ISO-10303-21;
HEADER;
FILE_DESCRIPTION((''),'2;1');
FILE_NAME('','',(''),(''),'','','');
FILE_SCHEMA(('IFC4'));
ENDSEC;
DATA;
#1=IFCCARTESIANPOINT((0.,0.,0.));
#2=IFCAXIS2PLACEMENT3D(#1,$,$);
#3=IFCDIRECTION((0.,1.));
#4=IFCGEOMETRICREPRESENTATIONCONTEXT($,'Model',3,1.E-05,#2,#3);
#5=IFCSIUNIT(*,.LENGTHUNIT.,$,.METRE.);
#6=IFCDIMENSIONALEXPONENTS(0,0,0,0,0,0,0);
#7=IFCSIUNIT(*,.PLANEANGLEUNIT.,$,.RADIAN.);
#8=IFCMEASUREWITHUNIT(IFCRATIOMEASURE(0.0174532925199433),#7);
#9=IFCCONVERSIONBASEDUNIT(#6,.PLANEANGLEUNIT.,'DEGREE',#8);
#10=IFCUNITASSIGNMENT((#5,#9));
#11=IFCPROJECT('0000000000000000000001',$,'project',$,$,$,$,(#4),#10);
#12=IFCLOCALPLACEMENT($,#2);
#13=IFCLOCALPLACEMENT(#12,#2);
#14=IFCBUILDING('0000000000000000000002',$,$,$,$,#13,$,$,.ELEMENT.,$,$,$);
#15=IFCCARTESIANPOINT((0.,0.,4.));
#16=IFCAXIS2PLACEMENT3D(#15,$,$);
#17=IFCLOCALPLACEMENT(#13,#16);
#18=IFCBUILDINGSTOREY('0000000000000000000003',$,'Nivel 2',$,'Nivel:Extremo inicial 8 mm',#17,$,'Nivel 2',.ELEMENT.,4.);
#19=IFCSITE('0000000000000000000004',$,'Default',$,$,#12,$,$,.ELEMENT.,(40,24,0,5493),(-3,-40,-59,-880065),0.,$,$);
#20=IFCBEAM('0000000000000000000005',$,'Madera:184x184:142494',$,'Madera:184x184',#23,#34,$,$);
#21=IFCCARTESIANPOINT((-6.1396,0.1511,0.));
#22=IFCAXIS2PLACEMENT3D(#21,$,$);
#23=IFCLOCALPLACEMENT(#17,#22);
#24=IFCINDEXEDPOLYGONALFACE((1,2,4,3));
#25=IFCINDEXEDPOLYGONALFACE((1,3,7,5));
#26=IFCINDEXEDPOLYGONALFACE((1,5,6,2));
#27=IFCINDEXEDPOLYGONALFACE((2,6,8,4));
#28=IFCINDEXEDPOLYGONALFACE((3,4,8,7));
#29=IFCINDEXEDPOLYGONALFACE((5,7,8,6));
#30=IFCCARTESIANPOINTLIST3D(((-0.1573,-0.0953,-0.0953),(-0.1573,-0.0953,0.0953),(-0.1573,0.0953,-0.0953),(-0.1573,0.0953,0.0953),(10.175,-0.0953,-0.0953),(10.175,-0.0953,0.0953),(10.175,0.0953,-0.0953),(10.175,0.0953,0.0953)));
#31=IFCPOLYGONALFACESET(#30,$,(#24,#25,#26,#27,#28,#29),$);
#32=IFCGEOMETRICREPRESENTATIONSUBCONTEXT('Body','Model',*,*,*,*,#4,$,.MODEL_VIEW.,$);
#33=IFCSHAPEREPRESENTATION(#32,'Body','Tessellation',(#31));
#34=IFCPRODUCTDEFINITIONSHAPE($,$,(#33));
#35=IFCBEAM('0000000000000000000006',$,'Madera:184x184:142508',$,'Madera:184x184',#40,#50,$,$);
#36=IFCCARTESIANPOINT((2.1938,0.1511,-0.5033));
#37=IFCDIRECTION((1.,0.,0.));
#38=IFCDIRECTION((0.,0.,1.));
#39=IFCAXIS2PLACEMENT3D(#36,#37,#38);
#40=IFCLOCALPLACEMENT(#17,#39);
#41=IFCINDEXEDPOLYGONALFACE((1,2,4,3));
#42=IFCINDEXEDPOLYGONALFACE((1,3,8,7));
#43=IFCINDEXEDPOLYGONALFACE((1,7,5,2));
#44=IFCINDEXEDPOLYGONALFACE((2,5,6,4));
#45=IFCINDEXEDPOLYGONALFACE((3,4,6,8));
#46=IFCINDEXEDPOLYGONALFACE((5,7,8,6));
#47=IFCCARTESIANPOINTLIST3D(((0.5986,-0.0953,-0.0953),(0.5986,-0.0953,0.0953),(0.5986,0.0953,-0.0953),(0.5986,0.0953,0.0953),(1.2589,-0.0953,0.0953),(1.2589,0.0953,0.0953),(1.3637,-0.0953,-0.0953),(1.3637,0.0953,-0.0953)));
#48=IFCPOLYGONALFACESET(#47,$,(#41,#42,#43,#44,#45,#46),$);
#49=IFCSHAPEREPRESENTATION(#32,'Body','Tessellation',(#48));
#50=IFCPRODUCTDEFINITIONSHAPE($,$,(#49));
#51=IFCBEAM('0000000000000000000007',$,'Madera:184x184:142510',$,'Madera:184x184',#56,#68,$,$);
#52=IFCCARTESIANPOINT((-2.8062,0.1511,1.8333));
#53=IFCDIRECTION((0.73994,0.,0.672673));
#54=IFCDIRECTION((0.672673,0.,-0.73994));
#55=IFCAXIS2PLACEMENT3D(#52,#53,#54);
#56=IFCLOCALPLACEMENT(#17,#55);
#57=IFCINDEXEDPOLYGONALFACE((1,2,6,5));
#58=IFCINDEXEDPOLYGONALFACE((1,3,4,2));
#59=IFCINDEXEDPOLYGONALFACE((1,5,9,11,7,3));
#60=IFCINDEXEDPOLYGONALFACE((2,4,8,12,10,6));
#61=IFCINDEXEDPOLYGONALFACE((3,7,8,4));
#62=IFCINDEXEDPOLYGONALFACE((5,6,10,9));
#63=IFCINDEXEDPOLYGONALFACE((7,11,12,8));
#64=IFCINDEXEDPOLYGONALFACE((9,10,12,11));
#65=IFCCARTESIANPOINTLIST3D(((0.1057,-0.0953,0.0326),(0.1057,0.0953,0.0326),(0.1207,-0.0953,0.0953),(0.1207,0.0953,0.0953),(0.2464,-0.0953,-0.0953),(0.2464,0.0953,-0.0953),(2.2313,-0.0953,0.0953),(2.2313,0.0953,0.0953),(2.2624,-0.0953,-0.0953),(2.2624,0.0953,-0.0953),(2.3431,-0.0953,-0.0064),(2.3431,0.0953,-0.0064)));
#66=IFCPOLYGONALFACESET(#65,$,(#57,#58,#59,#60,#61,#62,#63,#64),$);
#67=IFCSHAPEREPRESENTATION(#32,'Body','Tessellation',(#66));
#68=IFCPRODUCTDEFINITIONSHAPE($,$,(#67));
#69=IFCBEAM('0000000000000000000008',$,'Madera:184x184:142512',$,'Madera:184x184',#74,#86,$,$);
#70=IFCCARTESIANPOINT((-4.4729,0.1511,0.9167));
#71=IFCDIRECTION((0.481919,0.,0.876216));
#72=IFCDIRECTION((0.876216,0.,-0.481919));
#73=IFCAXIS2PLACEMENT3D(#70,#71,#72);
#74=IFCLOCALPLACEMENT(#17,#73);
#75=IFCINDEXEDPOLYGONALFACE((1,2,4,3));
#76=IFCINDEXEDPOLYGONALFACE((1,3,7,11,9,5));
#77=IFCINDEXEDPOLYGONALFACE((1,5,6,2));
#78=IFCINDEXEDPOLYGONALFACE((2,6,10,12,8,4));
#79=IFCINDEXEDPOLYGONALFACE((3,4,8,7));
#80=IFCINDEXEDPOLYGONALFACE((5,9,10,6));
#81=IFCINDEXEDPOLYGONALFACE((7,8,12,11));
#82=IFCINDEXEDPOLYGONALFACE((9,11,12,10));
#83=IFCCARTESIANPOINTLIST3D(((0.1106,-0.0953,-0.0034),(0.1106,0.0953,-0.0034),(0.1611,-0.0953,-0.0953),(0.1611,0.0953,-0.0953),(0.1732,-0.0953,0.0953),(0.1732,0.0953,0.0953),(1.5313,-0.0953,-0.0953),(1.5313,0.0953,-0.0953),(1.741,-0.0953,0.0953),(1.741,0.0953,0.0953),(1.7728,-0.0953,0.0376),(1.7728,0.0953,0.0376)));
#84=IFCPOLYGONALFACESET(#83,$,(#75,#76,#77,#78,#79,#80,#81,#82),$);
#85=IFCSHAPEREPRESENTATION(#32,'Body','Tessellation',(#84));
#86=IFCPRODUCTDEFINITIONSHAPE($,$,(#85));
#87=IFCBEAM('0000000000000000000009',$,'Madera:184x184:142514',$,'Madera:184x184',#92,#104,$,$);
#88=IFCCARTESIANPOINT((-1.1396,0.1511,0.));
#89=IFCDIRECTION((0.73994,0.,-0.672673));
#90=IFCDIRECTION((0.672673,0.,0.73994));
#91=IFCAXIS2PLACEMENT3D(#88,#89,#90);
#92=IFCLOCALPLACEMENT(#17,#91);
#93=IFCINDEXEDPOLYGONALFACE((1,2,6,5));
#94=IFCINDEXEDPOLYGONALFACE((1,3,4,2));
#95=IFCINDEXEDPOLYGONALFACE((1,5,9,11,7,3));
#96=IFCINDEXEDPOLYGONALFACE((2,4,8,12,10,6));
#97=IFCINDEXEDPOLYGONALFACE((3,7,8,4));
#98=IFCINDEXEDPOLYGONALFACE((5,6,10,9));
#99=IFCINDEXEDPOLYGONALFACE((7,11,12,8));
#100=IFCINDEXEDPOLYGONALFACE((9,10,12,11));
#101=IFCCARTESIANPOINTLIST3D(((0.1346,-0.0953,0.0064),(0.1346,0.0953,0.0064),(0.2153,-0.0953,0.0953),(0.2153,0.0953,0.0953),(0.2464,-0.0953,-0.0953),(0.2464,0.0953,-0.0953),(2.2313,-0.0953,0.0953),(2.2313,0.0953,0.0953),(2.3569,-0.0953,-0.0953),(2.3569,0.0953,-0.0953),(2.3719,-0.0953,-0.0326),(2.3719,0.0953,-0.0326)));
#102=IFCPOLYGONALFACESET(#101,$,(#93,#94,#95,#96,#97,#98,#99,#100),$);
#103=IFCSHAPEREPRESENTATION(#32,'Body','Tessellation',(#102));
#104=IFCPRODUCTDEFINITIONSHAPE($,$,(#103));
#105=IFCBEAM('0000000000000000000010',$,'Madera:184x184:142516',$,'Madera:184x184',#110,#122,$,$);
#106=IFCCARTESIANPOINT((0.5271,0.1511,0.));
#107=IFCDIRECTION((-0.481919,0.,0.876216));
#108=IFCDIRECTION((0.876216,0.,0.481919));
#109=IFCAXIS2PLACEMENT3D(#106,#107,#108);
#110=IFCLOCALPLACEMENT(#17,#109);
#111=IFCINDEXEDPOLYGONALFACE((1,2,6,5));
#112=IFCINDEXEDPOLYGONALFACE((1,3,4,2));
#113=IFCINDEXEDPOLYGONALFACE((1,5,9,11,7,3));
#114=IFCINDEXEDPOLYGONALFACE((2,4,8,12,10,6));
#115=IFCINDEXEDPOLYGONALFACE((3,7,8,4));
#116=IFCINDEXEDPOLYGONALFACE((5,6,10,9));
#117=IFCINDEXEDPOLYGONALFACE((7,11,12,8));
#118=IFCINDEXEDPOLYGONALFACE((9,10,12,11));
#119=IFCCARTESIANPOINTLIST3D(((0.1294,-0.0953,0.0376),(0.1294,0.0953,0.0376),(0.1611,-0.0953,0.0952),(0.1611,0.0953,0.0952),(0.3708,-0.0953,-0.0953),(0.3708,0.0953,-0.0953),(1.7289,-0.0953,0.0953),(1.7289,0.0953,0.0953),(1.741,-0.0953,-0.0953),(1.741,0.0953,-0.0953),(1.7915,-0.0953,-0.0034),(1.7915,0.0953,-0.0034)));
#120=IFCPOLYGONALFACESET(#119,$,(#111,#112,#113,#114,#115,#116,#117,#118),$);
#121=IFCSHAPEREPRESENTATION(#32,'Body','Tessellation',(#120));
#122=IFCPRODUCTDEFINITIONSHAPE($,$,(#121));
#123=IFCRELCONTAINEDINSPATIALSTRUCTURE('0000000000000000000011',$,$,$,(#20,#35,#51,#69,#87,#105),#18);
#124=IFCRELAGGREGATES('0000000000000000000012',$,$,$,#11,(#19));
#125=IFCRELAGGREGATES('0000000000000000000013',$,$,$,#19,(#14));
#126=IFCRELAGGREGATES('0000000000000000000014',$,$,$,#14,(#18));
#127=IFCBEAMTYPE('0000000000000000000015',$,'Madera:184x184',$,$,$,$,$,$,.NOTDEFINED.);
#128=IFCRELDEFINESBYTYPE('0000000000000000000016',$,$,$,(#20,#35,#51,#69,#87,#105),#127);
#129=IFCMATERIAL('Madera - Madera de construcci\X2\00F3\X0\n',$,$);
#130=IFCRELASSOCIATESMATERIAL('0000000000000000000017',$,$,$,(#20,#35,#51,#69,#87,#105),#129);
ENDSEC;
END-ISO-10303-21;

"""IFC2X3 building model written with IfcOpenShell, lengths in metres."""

from ifc_helpers import new_model, entity, si_unit, converted_unit, direction, frame, frame_2d, origin, origin_2d_with_axis, place, context, subcontext, project, spatial, rectangle, extrude, clip, halfspace, material, type_object, element, save


model = new_model("IFC2X3")

# Units and contexts
model_context = context("Model", 3, precision=1e-05, world=origin(), true_north=direction((0.0, 1.0)))
body_context = subcontext(model_context, "Body", "Model", "MODEL_VIEW")
ifc_project = project(units=[si_unit("LENGTHUNIT", "METRE"), converted_unit("PLANEANGLEUNIT", "DEGREE", entity("IfcRatioMeasure", 0.0174532925199433), si_unit("PLANEANGLEUNIT", "RADIAN"), dimensions=[0, 0, 0, 0, 0, 0, 0])], contexts=[model_context])

# Site, building, storey
site_placement = place(None, origin())
site = spatial("IfcSite", under=ifc_project, at=site_placement, Name="Default", CompositionType="ELEMENT", RefLatitude=(40, 24, 0, 5493), RefLongitude=(-3, -40, -59, -880065), RefElevation=0.0)
building_placement = place(site_placement, origin())
building = spatial("IfcBuilding", under=site, at=building_placement, CompositionType="ELEMENT")
storey_placement = place(building_placement, frame((0.0, 0.0, 4.0)))
storey = spatial("IfcBuildingStorey", under=building, at=storey_placement, Name="Nivel 2", ObjectType="Nivel:Extremo inicial 8 mm", LongName="Nivel 2", CompositionType="ELEMENT", Elevation=4.0)

# Beams
ifc_material = material(Name="Madera - Madera de construcción")
beam_type = type_object("IfcBeamType", Name="Madera:184x184", PredefinedType="NOTDEFINED")
beam_1_placement = place(storey_placement, frame((-6.1396, 0.1511, 0.0)))
element("IfcBeam", 1, at=beam_1_placement, inside=storey, type_object=beam_type, material=ifc_material, Name="Madera:184x184:142494", ObjectType="Madera:184x184", context=body_context, shape_type="SweptSolid", body=[
    extrude(rectangle(XDim=0.1905, YDim=0.1905, at=frame_2d((0.0, 0.0), x_axis=(1.0, 0.0))), frame((-0.1573, 0.0, 0.0), z_axis=(1.0, 0.0, 0.0), x_axis=(0.0, 0.0, -1.0)), (0.0, 0.0, 1.0), 10.3323),
])
beam_2_placement = place(storey_placement, frame((2.1938, 0.1511, -0.5033), z_axis=(1.0, 0.0, 0.0), x_axis=(0.0, 0.0, 1.0)))
element("IfcBeam", 2, at=beam_2_placement, inside=storey, type_object=beam_type, material=ifc_material, Name="Madera:184x184:142508", ObjectType="Madera:184x184", context=body_context, shape_type="Clipping", body=[
    clip(extrude(rectangle(XDim=0.1905, YDim=0.1905, at=origin_2d_with_axis()), frame((0.5986, 0.0, 0.0), z_axis=(1.0, 0.0, 0.0), x_axis=(0.0, 0.0, -1.0)), (0.0, 0.0, 1.0), 0.7651), halfspace(frame((3.1698, -0.0953, -3.3791), z_axis=(0.876216, 0.0, 0.481919), x_axis=(-0.481919, 0.0, 0.876216)), False)),
])
beam_3_placement = place(storey_placement, frame((-2.8062, 0.1511, 1.8333), z_axis=(0.73994, 0.0, 0.672673), x_axis=(0.672673, 0.0, -0.73994)))
element("IfcBeam", 3, at=beam_3_placement, inside=storey, type_object=beam_type, material=ifc_material, Name="Madera:184x184:142510", ObjectType="Madera:184x184", context=body_context, shape_type="Clipping", body=[
    clip(clip(clip(clip(extrude(rectangle(XDim=0.1905, YDim=0.1905, at=frame_2d((0.0, 0.0), x_axis=(0.0, 1.0))), frame((0.1057, 0.0, 0.0), z_axis=(1.0, 0.0, 0.0), x_axis=(0.0, 1.0, 0.0)), (0.0, 0.0, 1.0), 2.2374), halfspace(frame((-1.062, -0.0952, -3.752), z_axis=(0.73994, 0.0, -0.672673), x_axis=(0.672673, 0.0, 0.73994)), False)), halfspace(frame((1.6658, 0.0953, -1.3856), z_axis=(-0.672673, 0.0, -0.73994), x_axis=(-0.73994, 0.0, 0.672673)), False)), halfspace(frame((2.5646, -0.0952, -0.2077), z_axis=(0.672673, 0.0, 0.73994), x_axis=(-0.73994, 0.0, 0.672673)), False)), halfspace(frame((-0.8764, 0.0953, -4.0701), z_axis=(-0.972521, 0.0, 0.232816), x_axis=(0.232816, 0.0, 0.972521)), False)),
])
beam_4_placement = place(storey_placement, frame((-4.4729, 0.1511, 0.9167), z_axis=(0.481919, 0.0, 0.876216), x_axis=(0.876216, 0.0, -0.481919)))
element("IfcBeam", 4, at=beam_4_placement, inside=storey, type_object=beam_type, material=ifc_material, Name="Madera:184x184:142512", ObjectType="Madera:184x184", context=body_context, shape_type="Clipping", body=[
    clip(clip(clip(clip(extrude(rectangle(XDim=0.1905, YDim=0.1905, at=frame_2d((0.0, 0.0), x_axis=(0.0, 1.0))), frame((0.1106, 0.0, 0.0), z_axis=(1.0, 0.0, 0.0), x_axis=(0.0, 1.0, 0.0)), (0.0, 0.0, 1.0), 1.6622), halfspace(frame((-1.2023, -0.0953, -1.5987), z_axis=(0.481919, 0.0, -0.876216), x_axis=(0.876216, 0.0, 0.481919)), False)), halfspace(frame((0.6851, 0.0953, -1.0481), z_axis=(-0.876216, 0.0, -0.481919), x_axis=(-0.481919, 0.0, 0.876216)), False)), halfspace(frame((1.9783, -0.0952, -0.3362), z_axis=(0.876216, 0.0, 0.481919), x_axis=(-0.481919, 0.0, 0.876216)), False)), halfspace(frame((-1.1299, 0.0952, -1.9598), z_axis=(-0.84453, 0.0, 0.535509), x_axis=(0.535509, 0.0, 0.84453)), False)),
])
beam_5_placement = place(storey_placement, frame((-1.1396, 0.1511, 0.0), z_axis=(0.73994, 0.0, -0.672673), x_axis=(0.672673, 0.0, 0.73994)))
element("IfcBeam", 5, at=beam_5_placement, inside=storey, type_object=beam_type, material=ifc_material, Name="Madera:184x184:142514", ObjectType="Madera:184x184", context=body_context, shape_type="Clipping", body=[
    clip(clip(clip(clip(extrude(rectangle(XDim=0.1905, YDim=0.1905, at=frame_2d((0.0, 0.0), x_axis=(0.0, 1.0))), frame((0.1346, 0.0, 0.0), z_axis=(1.0, 0.0, 0.0), x_axis=(0.0, 1.0, 0.0)), (0.0, 0.0, 1.0), 2.2374), halfspace(frame((-3.3987, 0.0952, -3.8802), z_axis=(-0.73994, 0.0, 0.672673), x_axis=(0.672673, 0.0, 0.73994)), False)), halfspace(frame((-0.0869, -0.0953, 0.2077), z_axis=(-0.672673, 0.0, -0.73994), x_axis=(0.73994, 0.0, -0.672673)), False)), halfspace(frame((0.8569, 0.0953, 1.3447), z_axis=(0.672673, 0.0, 0.73994), x_axis=(0.73994, 0.0, -0.672673)), False)), halfspace(frame((1.9422, -0.0953, -1.8275), z_axis=(0.972521, 0.0, -0.232816), x_axis=(0.232816, 0.0, 0.972521)), False)),
])
beam_6_placement = place(storey_placement, frame((0.5271, 0.1511, 0.0), z_axis=(-0.481919, 0.0, 0.876216), x_axis=(0.876216, 0.0, 0.481919)))
element("IfcBeam", 6, at=beam_6_placement, inside=storey, type_object=beam_type, material=ifc_material, Name="Madera:184x184:142516", ObjectType="Madera:184x184", context=body_context, shape_type="Clipping", body=[
    clip(clip(clip(clip(extrude(rectangle(XDim=0.1905, YDim=0.1905, at=frame_2d((0.0, 0.0), x_axis=(0.0, 1.0))), frame((0.1294, 0.0, 0.0), z_axis=(1.0, 0.0, 0.0), x_axis=(0.0, 1.0, 0.0)), (0.0, 0.0, 1.0), 1.6622), halfspace(frame((-5.9334, -0.0953, 3.372), z_axis=(-0.481919, 0.0, -0.876216), x_axis=(0.876216, 0.0, -0.481919)), False)), halfspace(frame((-0.0469, 0.0953, -0.283), z_axis=(-0.876216, 0.0, 0.481919), x_axis=(0.481919, 0.0, 0.876216)), False)), halfspace(frame((1.1343, -0.0952, -1.1983), z_axis=(0.876216, 0.0, -0.481919), x_axis=(0.481919, 0.0, 0.876216)), False)), halfspace(frame((-0.2154, 0.0952, 3.1616), z_axis=(0.84453, 0.0, 0.535509), x_axis=(0.535509, 0.0, -0.84453)), False)),
])

save(model, "model.ifc")
